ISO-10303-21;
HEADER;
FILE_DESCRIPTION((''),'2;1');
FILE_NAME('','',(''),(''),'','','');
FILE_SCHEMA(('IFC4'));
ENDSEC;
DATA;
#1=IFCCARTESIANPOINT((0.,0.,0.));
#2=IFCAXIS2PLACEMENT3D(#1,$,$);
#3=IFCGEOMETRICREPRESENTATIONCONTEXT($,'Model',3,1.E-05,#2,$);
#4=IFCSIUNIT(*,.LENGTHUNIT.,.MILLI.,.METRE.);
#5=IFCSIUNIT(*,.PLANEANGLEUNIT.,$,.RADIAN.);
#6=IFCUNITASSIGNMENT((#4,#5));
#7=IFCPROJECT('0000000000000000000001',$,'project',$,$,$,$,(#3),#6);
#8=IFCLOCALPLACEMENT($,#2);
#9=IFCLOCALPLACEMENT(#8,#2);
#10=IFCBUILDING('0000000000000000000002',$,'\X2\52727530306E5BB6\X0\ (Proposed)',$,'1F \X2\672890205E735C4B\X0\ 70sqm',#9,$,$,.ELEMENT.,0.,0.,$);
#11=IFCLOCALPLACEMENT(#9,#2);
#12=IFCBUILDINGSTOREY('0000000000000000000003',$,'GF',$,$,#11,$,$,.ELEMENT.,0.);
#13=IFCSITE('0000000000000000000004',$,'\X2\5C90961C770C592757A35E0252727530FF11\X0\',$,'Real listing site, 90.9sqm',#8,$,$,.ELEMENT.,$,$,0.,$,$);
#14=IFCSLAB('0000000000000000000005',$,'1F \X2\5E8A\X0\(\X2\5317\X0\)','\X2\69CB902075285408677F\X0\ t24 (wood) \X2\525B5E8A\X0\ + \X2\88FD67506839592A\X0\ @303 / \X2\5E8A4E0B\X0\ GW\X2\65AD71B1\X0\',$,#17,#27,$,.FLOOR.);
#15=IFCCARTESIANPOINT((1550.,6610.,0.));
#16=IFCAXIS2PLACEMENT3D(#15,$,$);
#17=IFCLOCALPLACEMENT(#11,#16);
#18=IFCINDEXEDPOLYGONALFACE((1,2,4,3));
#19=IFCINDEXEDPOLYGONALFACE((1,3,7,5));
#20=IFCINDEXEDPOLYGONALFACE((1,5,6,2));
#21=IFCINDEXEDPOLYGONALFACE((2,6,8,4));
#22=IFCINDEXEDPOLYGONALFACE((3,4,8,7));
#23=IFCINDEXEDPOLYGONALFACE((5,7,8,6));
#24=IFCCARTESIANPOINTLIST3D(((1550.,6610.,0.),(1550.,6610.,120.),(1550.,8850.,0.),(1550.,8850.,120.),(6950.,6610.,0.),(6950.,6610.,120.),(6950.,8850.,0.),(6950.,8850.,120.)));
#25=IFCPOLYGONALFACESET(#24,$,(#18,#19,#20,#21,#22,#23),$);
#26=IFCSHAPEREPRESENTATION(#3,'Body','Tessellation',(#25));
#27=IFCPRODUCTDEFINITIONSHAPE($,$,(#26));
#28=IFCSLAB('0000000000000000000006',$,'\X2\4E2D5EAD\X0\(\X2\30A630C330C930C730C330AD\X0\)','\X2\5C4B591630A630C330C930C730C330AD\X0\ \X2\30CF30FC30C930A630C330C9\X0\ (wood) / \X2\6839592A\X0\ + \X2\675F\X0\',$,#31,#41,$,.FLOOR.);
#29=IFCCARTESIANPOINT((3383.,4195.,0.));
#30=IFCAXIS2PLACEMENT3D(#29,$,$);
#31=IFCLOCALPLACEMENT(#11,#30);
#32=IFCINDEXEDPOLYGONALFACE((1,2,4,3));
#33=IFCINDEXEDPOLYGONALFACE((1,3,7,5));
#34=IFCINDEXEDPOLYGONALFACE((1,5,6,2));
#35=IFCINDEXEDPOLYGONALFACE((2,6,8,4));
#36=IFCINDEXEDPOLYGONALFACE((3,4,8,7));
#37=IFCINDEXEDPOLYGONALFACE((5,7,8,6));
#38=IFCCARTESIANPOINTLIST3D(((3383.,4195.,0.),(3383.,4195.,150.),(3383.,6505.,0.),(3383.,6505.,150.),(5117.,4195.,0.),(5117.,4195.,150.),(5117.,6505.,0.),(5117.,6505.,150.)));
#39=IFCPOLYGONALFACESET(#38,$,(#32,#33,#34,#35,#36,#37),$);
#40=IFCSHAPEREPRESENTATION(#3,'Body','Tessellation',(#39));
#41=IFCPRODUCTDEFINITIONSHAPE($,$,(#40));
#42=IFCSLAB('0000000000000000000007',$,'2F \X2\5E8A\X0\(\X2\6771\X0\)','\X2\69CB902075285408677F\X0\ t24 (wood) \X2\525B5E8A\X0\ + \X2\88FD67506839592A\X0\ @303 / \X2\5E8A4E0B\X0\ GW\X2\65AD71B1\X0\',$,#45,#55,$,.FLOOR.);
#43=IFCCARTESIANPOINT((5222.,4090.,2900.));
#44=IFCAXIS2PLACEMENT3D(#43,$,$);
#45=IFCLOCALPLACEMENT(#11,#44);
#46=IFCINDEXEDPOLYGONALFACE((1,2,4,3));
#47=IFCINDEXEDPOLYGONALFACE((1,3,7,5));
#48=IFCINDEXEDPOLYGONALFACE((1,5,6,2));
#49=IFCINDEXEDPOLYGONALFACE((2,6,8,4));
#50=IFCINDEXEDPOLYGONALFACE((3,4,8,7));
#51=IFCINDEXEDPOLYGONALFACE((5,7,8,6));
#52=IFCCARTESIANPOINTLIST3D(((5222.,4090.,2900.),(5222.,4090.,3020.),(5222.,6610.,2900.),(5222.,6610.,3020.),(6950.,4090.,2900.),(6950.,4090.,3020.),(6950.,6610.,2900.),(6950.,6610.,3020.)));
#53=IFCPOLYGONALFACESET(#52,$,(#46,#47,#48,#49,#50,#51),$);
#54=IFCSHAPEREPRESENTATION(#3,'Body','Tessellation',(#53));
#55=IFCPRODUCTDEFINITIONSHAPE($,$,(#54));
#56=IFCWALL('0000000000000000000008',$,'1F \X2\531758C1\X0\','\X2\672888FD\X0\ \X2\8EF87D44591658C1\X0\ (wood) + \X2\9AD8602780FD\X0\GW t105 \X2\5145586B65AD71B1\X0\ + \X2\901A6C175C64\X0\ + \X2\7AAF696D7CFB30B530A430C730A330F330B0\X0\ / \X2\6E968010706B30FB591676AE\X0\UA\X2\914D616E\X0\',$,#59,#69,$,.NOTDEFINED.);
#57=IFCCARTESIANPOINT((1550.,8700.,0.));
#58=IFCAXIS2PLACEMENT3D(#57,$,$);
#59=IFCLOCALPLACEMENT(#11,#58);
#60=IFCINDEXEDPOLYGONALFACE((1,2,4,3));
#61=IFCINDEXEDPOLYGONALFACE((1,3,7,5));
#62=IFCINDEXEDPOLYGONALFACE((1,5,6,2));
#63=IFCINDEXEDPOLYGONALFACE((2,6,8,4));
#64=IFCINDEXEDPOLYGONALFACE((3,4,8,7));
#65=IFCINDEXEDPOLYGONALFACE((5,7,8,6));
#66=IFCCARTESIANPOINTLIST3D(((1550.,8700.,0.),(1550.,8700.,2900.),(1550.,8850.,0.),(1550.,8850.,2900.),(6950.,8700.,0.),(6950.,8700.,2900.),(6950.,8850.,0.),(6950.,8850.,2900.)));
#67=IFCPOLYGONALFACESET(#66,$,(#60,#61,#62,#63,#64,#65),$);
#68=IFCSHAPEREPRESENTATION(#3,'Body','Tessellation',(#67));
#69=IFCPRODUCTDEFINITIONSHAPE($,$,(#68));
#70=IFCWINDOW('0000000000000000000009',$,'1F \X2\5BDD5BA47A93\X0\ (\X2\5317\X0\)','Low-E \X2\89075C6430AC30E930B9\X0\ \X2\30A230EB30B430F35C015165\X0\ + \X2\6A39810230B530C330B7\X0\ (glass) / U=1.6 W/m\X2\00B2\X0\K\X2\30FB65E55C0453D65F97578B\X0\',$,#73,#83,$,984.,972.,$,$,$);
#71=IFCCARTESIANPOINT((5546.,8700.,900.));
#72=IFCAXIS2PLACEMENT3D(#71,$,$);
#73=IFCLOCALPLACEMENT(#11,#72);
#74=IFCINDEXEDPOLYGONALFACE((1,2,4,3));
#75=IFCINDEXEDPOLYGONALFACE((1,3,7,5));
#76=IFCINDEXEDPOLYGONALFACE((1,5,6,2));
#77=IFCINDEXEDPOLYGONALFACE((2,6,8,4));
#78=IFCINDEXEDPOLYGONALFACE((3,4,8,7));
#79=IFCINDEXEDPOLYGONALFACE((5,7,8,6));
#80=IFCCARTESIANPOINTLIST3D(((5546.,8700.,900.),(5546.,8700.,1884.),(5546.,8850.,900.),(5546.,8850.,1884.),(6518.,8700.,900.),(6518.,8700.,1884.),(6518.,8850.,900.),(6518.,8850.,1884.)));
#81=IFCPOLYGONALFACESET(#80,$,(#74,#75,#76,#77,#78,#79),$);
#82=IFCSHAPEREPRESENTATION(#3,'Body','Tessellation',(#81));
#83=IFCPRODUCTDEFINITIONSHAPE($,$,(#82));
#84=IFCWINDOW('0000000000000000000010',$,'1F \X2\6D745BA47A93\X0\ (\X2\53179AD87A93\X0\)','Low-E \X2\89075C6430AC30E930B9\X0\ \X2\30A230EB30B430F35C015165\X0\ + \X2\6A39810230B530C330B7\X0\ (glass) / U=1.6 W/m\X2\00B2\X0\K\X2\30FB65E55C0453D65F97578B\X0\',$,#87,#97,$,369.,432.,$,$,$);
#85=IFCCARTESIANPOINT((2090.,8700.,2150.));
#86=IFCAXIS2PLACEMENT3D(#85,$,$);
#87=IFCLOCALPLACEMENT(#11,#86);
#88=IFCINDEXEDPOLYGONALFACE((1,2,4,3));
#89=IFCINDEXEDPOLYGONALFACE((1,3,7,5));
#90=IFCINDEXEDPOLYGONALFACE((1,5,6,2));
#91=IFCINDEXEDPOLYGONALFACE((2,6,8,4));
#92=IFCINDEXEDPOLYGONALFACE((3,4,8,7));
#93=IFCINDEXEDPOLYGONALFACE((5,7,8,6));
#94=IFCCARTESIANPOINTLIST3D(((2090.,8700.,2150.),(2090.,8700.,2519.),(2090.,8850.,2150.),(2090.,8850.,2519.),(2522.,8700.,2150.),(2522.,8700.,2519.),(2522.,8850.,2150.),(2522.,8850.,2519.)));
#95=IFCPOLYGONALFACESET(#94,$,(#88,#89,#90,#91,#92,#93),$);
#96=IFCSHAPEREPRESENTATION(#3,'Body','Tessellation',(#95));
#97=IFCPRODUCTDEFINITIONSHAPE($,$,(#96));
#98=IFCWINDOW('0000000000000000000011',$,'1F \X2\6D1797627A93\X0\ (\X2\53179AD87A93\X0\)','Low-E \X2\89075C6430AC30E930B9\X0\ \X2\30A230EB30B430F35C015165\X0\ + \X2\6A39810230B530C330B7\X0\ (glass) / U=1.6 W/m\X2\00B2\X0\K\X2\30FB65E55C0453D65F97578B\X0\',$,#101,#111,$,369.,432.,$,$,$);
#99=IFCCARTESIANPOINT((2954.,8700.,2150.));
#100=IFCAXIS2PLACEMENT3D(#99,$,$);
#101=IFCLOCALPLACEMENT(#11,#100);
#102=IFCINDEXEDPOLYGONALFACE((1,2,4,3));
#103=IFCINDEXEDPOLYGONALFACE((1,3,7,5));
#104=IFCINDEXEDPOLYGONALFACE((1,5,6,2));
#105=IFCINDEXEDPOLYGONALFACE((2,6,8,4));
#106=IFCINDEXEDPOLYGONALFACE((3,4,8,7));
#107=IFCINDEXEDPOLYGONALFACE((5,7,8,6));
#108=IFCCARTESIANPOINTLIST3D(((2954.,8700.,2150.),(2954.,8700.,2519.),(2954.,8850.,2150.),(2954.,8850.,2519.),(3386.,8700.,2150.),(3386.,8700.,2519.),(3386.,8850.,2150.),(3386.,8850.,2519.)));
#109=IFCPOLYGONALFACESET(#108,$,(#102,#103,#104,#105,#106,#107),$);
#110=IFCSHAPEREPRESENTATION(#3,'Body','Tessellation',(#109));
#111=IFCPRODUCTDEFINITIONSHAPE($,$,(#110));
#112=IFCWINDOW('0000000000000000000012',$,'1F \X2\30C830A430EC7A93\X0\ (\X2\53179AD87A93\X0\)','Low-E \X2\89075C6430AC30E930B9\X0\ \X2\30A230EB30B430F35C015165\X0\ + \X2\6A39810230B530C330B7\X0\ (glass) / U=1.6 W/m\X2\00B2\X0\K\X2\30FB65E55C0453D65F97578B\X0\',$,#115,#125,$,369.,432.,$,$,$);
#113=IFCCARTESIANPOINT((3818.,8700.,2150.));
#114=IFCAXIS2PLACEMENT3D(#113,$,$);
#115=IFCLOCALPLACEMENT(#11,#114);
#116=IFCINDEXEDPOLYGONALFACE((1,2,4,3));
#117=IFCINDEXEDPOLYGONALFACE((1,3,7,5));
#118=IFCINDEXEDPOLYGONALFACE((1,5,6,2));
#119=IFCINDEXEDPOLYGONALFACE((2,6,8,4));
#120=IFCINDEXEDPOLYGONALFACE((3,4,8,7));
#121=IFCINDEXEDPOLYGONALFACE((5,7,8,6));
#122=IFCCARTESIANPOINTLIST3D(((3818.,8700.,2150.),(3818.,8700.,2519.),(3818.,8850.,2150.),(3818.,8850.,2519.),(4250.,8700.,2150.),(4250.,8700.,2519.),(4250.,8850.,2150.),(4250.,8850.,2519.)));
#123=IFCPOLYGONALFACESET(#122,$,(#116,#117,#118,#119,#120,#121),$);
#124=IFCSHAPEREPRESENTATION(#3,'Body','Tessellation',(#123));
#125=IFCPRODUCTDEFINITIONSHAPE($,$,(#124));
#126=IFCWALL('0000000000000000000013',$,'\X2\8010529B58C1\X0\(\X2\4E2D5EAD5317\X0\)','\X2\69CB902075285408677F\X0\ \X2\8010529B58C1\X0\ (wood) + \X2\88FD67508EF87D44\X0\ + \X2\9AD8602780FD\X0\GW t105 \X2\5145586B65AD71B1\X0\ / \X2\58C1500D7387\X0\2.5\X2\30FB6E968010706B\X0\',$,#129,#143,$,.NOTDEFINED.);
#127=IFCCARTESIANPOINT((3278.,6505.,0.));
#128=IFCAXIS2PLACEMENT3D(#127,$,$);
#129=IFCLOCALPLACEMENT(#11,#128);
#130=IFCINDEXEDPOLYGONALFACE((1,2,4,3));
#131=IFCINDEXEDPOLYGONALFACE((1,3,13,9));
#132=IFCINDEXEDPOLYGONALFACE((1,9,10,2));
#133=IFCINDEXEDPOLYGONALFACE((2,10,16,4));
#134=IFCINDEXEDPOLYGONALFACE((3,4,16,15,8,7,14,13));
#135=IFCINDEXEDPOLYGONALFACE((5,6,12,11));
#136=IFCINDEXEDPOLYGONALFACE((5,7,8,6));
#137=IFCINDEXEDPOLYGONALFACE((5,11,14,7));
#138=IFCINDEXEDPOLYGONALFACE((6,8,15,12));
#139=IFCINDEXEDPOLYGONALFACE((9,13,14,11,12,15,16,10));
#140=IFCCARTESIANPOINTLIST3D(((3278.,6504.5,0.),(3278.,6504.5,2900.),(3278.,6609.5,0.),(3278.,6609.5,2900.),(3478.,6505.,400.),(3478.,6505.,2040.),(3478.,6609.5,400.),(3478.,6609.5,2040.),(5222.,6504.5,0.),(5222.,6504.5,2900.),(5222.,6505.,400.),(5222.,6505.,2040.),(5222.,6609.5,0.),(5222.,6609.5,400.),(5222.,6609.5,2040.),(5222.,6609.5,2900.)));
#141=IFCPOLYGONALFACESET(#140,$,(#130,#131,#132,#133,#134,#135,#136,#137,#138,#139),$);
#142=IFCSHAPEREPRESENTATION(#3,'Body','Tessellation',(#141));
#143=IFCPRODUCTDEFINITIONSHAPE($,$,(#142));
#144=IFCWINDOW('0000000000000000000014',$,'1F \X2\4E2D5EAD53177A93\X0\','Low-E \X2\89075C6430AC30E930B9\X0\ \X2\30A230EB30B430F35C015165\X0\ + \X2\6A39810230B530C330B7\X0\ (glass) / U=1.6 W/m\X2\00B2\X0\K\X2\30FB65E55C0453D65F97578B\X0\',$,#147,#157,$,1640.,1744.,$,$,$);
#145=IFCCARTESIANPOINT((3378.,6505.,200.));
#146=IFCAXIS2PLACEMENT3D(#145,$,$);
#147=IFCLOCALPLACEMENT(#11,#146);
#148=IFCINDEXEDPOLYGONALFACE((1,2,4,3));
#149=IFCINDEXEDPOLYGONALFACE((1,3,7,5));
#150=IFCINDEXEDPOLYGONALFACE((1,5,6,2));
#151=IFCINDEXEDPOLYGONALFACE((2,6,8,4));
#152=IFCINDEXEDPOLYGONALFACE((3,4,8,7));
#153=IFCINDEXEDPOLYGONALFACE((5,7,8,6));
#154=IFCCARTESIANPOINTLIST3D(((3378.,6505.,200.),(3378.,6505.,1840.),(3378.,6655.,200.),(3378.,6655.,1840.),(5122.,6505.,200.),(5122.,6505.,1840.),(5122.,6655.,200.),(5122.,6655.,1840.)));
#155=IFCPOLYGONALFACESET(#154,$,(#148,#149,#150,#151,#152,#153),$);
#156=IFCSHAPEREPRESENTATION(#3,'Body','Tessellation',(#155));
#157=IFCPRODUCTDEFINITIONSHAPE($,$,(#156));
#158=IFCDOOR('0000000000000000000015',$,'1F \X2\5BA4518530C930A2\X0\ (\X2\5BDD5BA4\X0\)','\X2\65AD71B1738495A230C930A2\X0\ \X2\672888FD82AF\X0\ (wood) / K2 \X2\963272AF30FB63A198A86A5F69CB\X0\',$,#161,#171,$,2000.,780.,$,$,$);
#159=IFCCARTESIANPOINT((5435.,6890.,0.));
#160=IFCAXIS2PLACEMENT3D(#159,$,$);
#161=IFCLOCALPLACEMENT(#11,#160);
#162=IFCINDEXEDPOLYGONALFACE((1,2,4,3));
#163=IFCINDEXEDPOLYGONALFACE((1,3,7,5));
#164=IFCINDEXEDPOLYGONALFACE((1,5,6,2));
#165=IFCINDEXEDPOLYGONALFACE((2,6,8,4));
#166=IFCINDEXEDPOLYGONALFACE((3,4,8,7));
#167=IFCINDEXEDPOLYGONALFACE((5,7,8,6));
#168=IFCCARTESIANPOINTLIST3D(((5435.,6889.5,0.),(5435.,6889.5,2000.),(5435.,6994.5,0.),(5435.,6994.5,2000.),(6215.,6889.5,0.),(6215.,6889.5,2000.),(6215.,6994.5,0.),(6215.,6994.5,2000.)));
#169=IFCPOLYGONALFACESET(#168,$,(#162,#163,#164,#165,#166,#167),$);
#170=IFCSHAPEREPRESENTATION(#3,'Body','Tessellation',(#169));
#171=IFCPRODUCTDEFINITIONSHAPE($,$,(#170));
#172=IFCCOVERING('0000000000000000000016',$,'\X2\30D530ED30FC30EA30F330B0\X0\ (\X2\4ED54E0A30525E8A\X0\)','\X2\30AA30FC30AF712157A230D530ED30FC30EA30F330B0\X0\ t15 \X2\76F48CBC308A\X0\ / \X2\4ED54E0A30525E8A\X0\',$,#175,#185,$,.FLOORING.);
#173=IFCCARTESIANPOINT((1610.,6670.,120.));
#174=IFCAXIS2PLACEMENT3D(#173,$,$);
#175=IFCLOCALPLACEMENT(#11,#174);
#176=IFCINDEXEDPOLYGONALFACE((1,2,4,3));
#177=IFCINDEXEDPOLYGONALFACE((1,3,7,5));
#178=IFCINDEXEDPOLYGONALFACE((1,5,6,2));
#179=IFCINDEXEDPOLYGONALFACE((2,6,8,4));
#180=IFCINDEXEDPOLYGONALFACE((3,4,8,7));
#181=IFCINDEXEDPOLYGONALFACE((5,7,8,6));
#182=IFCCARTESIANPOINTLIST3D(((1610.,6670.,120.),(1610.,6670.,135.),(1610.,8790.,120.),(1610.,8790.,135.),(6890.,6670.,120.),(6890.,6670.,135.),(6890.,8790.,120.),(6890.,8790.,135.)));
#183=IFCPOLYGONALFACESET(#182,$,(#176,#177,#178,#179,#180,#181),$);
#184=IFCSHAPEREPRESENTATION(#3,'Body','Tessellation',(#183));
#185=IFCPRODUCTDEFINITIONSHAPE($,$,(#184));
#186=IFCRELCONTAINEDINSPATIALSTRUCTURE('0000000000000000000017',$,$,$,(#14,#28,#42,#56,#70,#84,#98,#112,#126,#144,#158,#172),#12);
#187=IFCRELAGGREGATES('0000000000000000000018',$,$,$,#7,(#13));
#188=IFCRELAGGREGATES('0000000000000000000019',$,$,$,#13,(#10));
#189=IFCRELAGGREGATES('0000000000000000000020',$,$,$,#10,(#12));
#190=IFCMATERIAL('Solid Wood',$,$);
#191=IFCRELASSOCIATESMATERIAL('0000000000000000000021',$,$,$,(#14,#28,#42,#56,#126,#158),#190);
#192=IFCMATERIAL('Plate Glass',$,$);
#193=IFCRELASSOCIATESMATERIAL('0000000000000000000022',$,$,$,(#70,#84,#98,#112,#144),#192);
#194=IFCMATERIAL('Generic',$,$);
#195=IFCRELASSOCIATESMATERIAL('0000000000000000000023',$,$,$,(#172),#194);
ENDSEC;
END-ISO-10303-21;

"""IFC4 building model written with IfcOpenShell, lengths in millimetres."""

from ifc_helpers import new_model, si_unit, frame, frame_2d, origin, place, context, project, spatial, rectangle, extrude, material, element, fill, save


model = new_model("IFC4")

# Units and contexts
model_context = context("Model", 3, precision=1e-05, world=origin())
ifc_project = project(units=[si_unit("LENGTHUNIT", "METRE", prefix="MILLI"), si_unit("PLANEANGLEUNIT", "RADIAN")], contexts=[model_context])

# Site, building, storey
site_placement = place(None, origin())
site = spatial("IfcSite", under=ifc_project, at=site_placement, Name="岐阜県大垣市割田１", ObjectType="Real listing site, 90.9sqm", CompositionType="ELEMENT", RefElevation=0.0)
building_placement = place(site_placement, origin())
building = spatial("IfcBuilding", under=site, at=building_placement, Name="割田の家 (Proposed)", ObjectType="1F 木造平屋 70sqm", CompositionType="ELEMENT", ElevationOfRefHeight=0.0, ElevationOfTerrain=0.0)
storey_placement = place(building_placement, origin())
storey = spatial("IfcBuildingStorey", under=building, at=storey_placement, Name="GF", CompositionType="ELEMENT", Elevation=0.0)

# Slabs
ifc_material_1 = material(Name="Solid Wood")
slab_1_placement = place(storey_placement, frame((1550.0, 6610.0, 0.0)))
element("IfcSlab", 1, at=slab_1_placement, inside=storey, material=ifc_material_1, Name="1F 床(北)", Description="構造用合板 t24 (wood) 剛床 + 製材根太 @303 / 床下 GW断熱", PredefinedType="FLOOR", context=model_context, shape_type="SweptSolid", body=[
    extrude(rectangle(XDim=5400.0, YDim=2240.0, at=frame_2d((2700.0, 1120.0))), frame((1550.0, 6610.0, 0.0)), (0.0, 0.0, 1.0), 120.0),
])
slab_2_placement = place(storey_placement, frame((3383.0, 4195.0, 0.0)))
element("IfcSlab", 2, at=slab_2_placement, inside=storey, material=ifc_material_1, Name="中庭(ウッドデッキ)", Description="屋外ウッドデッキ ハードウッド (wood) / 根太 + 束", PredefinedType="FLOOR", context=model_context, shape_type="SweptSolid", body=[
    extrude(rectangle(XDim=1734.0, YDim=2310.0, at=frame_2d((867.0, 1155.0))), frame((3383.0, 4195.0, 0.0)), (0.0, 0.0, 1.0), 150.0),
])
slab_3_placement = place(storey_placement, frame((5222.0, 4090.0, 2900.0)))
element("IfcSlab", 3, at=slab_3_placement, inside=storey, material=ifc_material_1, Name="2F 床(東)", Description="構造用合板 t24 (wood) 剛床 + 製材根太 @303 / 床下 GW断熱", PredefinedType="FLOOR", context=model_context, shape_type="SweptSolid", body=[
    extrude(rectangle(XDim=1728.0, YDim=2520.0, at=frame_2d((864.0, 1260.0))), frame((5222.0, 4090.0, 2900.0)), (0.0, 0.0, 1.0), 120.0),
])

# Wall, openings, windows
wall_1_placement = place(storey_placement, frame((1550.0, 8700.0, 0.0)))
wall_1 = element("IfcWall", 4, at=wall_1_placement, inside=storey, material=ifc_material_1, Name="1F 北壁", Description="木製 軸組外壁 (wood) + 高性能GW t105 充填断熱 + 通気層 + 窯業系サイディング / 準耐火・外皮UA配慮", PredefinedType="NOTDEFINED", context=model_context, shape_type="SweptSolid", body=[
    extrude(rectangle(XDim=5400.0, YDim=150.0, at=frame_2d((2700.0, 75.0))), frame((1550.0, 8700.0, 0.0)), (0.0, 0.0, 1.0), 2900.0),
])
opening_1_placement = place(storey_placement, frame((5546.0, 8700.0, 900.0)))
opening_1 = element("IfcOpeningElement", 5, at=opening_1_placement, cuts=wall_1, PredefinedType="NOTDEFINED", context=model_context, shape_type="SweptSolid", body=[
    extrude(rectangle(XDim=972.0, YDim=150.0, at=frame_2d((486.0, 75.0))), frame((5546.0, 8700.0, 900.0)), (0.0, 0.0, 1.0), 984.0),
])
opening_2_placement = place(storey_placement, frame((2090.0, 8700.0, 2150.0)))
opening_2 = element("IfcOpeningElement", 6, at=opening_2_placement, cuts=wall_1, PredefinedType="NOTDEFINED", context=model_context, shape_type="SweptSolid", body=[
    extrude(rectangle(XDim=432.0, YDim=150.0, at=frame_2d((216.0, 75.0))), frame((2090.0, 8700.0, 2150.0)), (0.0, 0.0, 1.0), 369.0),
])
opening_3_placement = place(storey_placement, frame((2954.0, 8700.0, 2150.0)))
opening_3 = element("IfcOpeningElement", 7, at=opening_3_placement, cuts=wall_1, PredefinedType="NOTDEFINED", context=model_context, shape_type="SweptSolid", body=[
    extrude(rectangle(XDim=432.0, YDim=150.0, at=frame_2d((216.0, 75.0))), frame((2954.0, 8700.0, 2150.0)), (0.0, 0.0, 1.0), 369.0),
])
opening_4_placement = place(storey_placement, frame((3818.0, 8700.0, 2150.0)))
opening_4 = element("IfcOpeningElement", 8, at=opening_4_placement, cuts=wall_1, PredefinedType="NOTDEFINED", context=model_context, shape_type="SweptSolid", body=[
    extrude(rectangle(XDim=432.0, YDim=150.0, at=frame_2d((216.0, 75.0))), frame((3818.0, 8700.0, 2150.0)), (0.0, 0.0, 1.0), 369.0),
])
ifc_material_2 = material(Name="Plate Glass")
window_1_placement = place(storey_placement, frame((5546.0, 8700.0, 900.0)))
window_1 = element("IfcWindow", 9, at=window_1_placement, inside=storey, material=ifc_material_2, Name="1F 寝室窓 (北)", Description="Low-E 複層ガラス アルゴン封入 + 樹脂サッシ (glass) / U=1.6 W/m²K・日射取得型", OverallHeight=984.0, OverallWidth=972.0, context=model_context, shape_type="SweptSolid", body=[
    extrude(rectangle(XDim=972.0, YDim=150.0, at=frame_2d((486.0, 75.0))), frame((5546.0, 8700.0, 900.0)), (0.0, 0.0, 1.0), 984.0),
])
fill(opening_1, window_1)
window_2_placement = place(storey_placement, frame((2090.0, 8700.0, 2150.0)))
window_2 = element("IfcWindow", 10, at=window_2_placement, inside=storey, material=ifc_material_2, Name="1F 浴室窓 (北高窓)", Description="Low-E 複層ガラス アルゴン封入 + 樹脂サッシ (glass) / U=1.6 W/m²K・日射取得型", OverallHeight=369.0, OverallWidth=432.0, context=model_context, shape_type="SweptSolid", body=[
    extrude(rectangle(XDim=432.0, YDim=150.0, at=frame_2d((216.0, 75.0))), frame((2090.0, 8700.0, 2150.0)), (0.0, 0.0, 1.0), 369.0),
])
fill(opening_2, window_2)
window_3_placement = place(storey_placement, frame((2954.0, 8700.0, 2150.0)))
window_3 = element("IfcWindow", 11, at=window_3_placement, inside=storey, material=ifc_material_2, Name="1F 洗面窓 (北高窓)", Description="Low-E 複層ガラス アルゴン封入 + 樹脂サッシ (glass) / U=1.6 W/m²K・日射取得型", OverallHeight=369.0, OverallWidth=432.0, context=model_context, shape_type="SweptSolid", body=[
    extrude(rectangle(XDim=432.0, YDim=150.0, at=frame_2d((216.0, 75.0))), frame((2954.0, 8700.0, 2150.0)), (0.0, 0.0, 1.0), 369.0),
])
fill(opening_3, window_3)
window_4_placement = place(storey_placement, frame((3818.0, 8700.0, 2150.0)))
window_4 = element("IfcWindow", 12, at=window_4_placement, inside=storey, material=ifc_material_2, Name="1F トイレ窓 (北高窓)", Description="Low-E 複層ガラス アルゴン封入 + 樹脂サッシ (glass) / U=1.6 W/m²K・日射取得型", OverallHeight=369.0, OverallWidth=432.0, context=model_context, shape_type="SweptSolid", body=[
    extrude(rectangle(XDim=432.0, YDim=150.0, at=frame_2d((216.0, 75.0))), frame((3818.0, 8700.0, 2150.0)), (0.0, 0.0, 1.0), 369.0),
])
fill(opening_4, window_4)

# Wall, opening, window
wall_2_placement = place(storey_placement, frame((3278.0, 6505.0, 0.0)))
wall_2 = element("IfcWall", 13, at=wall_2_placement, inside=storey, material=ifc_material_1, Name="耐力壁(中庭北)", Description="構造用合板 耐力壁 (wood) + 製材軸組 + 高性能GW t105 充填断熱 / 壁倍率2.5・準耐火", PredefinedType="NOTDEFINED", context=model_context, shape_type="SweptSolid", body=[
    extrude(rectangle(XDim=1944.0, YDim=105.0, at=frame_2d((972.0, 52.0))), frame((3278.0, 6505.0, 0.0)), (0.0, 0.0, 1.0), 2900.0),
])
opening_5_placement = place(storey_placement, frame((3378.0, 6505.0, 200.0)))
opening_5 = element("IfcOpeningElement", 14, at=opening_5_placement, cuts=wall_2, PredefinedType="NOTDEFINED", context=model_context, shape_type="SweptSolid", body=[
    extrude(rectangle(XDim=1744.0, YDim=150.0, at=frame_2d((872.0, 75.0))), frame((3378.0, 6505.0, 200.0)), (0.0, 0.0, 1.0), 1640.0),
])
window_5_placement = place(storey_placement, frame((3378.0, 6505.0, 200.0)))
window_5 = element("IfcWindow", 15, at=window_5_placement, inside=storey, material=ifc_material_2, Name="1F 中庭北窓", Description="Low-E 複層ガラス アルゴン封入 + 樹脂サッシ (glass) / U=1.6 W/m²K・日射取得型", OverallHeight=1640.0, OverallWidth=1744.0, context=model_context, shape_type="SweptSolid", body=[
    extrude(rectangle(XDim=1744.0, YDim=150.0, at=frame_2d((872.0, 75.0))), frame((3378.0, 6505.0, 200.0)), (0.0, 0.0, 1.0), 1640.0),
])
fill(opening_5, window_5)

# Door
door_1_placement = place(storey_placement, frame((5435.0, 6890.0, 0.0)))
element("IfcDoor", 16, at=door_1_placement, inside=storey, material=ifc_material_1, Name="1F 室内ドア (寝室)", Description="断熱玄関ドア 木製芯 (wood) / K2 防犯・採風機構", OverallHeight=2000.0, OverallWidth=780.0, context=model_context, shape_type="SweptSolid", body=[
    extrude(rectangle(XDim=780.0, YDim=105.0, at=frame_2d((390.0, 52.0))), frame((5435.0, 6890.0, 0.0)), (0.0, 0.0, 1.0), 2000.0),
])

# Covering
ifc_material_3 = material(Name="Generic")
covering_1_placement = place(storey_placement, frame((1610.0, 6670.0, 120.0)))
element("IfcCovering", 17, at=covering_1_placement, inside=storey, material=ifc_material_3, Name="フローリング (仕上げ床)", Description="オーク無垢フローリング t15 直貼り / 仕上げ床", PredefinedType="FLOORING", context=model_context, shape_type="SweptSolid", body=[
    extrude(rectangle(XDim=5280.0, YDim=2120.0, at=frame_2d((2640.0, 1060.0))), frame((1610.0, 6670.0, 120.0)), (0.0, 0.0, 1.0), 15.0),
])

save(model, "model.ifc")
